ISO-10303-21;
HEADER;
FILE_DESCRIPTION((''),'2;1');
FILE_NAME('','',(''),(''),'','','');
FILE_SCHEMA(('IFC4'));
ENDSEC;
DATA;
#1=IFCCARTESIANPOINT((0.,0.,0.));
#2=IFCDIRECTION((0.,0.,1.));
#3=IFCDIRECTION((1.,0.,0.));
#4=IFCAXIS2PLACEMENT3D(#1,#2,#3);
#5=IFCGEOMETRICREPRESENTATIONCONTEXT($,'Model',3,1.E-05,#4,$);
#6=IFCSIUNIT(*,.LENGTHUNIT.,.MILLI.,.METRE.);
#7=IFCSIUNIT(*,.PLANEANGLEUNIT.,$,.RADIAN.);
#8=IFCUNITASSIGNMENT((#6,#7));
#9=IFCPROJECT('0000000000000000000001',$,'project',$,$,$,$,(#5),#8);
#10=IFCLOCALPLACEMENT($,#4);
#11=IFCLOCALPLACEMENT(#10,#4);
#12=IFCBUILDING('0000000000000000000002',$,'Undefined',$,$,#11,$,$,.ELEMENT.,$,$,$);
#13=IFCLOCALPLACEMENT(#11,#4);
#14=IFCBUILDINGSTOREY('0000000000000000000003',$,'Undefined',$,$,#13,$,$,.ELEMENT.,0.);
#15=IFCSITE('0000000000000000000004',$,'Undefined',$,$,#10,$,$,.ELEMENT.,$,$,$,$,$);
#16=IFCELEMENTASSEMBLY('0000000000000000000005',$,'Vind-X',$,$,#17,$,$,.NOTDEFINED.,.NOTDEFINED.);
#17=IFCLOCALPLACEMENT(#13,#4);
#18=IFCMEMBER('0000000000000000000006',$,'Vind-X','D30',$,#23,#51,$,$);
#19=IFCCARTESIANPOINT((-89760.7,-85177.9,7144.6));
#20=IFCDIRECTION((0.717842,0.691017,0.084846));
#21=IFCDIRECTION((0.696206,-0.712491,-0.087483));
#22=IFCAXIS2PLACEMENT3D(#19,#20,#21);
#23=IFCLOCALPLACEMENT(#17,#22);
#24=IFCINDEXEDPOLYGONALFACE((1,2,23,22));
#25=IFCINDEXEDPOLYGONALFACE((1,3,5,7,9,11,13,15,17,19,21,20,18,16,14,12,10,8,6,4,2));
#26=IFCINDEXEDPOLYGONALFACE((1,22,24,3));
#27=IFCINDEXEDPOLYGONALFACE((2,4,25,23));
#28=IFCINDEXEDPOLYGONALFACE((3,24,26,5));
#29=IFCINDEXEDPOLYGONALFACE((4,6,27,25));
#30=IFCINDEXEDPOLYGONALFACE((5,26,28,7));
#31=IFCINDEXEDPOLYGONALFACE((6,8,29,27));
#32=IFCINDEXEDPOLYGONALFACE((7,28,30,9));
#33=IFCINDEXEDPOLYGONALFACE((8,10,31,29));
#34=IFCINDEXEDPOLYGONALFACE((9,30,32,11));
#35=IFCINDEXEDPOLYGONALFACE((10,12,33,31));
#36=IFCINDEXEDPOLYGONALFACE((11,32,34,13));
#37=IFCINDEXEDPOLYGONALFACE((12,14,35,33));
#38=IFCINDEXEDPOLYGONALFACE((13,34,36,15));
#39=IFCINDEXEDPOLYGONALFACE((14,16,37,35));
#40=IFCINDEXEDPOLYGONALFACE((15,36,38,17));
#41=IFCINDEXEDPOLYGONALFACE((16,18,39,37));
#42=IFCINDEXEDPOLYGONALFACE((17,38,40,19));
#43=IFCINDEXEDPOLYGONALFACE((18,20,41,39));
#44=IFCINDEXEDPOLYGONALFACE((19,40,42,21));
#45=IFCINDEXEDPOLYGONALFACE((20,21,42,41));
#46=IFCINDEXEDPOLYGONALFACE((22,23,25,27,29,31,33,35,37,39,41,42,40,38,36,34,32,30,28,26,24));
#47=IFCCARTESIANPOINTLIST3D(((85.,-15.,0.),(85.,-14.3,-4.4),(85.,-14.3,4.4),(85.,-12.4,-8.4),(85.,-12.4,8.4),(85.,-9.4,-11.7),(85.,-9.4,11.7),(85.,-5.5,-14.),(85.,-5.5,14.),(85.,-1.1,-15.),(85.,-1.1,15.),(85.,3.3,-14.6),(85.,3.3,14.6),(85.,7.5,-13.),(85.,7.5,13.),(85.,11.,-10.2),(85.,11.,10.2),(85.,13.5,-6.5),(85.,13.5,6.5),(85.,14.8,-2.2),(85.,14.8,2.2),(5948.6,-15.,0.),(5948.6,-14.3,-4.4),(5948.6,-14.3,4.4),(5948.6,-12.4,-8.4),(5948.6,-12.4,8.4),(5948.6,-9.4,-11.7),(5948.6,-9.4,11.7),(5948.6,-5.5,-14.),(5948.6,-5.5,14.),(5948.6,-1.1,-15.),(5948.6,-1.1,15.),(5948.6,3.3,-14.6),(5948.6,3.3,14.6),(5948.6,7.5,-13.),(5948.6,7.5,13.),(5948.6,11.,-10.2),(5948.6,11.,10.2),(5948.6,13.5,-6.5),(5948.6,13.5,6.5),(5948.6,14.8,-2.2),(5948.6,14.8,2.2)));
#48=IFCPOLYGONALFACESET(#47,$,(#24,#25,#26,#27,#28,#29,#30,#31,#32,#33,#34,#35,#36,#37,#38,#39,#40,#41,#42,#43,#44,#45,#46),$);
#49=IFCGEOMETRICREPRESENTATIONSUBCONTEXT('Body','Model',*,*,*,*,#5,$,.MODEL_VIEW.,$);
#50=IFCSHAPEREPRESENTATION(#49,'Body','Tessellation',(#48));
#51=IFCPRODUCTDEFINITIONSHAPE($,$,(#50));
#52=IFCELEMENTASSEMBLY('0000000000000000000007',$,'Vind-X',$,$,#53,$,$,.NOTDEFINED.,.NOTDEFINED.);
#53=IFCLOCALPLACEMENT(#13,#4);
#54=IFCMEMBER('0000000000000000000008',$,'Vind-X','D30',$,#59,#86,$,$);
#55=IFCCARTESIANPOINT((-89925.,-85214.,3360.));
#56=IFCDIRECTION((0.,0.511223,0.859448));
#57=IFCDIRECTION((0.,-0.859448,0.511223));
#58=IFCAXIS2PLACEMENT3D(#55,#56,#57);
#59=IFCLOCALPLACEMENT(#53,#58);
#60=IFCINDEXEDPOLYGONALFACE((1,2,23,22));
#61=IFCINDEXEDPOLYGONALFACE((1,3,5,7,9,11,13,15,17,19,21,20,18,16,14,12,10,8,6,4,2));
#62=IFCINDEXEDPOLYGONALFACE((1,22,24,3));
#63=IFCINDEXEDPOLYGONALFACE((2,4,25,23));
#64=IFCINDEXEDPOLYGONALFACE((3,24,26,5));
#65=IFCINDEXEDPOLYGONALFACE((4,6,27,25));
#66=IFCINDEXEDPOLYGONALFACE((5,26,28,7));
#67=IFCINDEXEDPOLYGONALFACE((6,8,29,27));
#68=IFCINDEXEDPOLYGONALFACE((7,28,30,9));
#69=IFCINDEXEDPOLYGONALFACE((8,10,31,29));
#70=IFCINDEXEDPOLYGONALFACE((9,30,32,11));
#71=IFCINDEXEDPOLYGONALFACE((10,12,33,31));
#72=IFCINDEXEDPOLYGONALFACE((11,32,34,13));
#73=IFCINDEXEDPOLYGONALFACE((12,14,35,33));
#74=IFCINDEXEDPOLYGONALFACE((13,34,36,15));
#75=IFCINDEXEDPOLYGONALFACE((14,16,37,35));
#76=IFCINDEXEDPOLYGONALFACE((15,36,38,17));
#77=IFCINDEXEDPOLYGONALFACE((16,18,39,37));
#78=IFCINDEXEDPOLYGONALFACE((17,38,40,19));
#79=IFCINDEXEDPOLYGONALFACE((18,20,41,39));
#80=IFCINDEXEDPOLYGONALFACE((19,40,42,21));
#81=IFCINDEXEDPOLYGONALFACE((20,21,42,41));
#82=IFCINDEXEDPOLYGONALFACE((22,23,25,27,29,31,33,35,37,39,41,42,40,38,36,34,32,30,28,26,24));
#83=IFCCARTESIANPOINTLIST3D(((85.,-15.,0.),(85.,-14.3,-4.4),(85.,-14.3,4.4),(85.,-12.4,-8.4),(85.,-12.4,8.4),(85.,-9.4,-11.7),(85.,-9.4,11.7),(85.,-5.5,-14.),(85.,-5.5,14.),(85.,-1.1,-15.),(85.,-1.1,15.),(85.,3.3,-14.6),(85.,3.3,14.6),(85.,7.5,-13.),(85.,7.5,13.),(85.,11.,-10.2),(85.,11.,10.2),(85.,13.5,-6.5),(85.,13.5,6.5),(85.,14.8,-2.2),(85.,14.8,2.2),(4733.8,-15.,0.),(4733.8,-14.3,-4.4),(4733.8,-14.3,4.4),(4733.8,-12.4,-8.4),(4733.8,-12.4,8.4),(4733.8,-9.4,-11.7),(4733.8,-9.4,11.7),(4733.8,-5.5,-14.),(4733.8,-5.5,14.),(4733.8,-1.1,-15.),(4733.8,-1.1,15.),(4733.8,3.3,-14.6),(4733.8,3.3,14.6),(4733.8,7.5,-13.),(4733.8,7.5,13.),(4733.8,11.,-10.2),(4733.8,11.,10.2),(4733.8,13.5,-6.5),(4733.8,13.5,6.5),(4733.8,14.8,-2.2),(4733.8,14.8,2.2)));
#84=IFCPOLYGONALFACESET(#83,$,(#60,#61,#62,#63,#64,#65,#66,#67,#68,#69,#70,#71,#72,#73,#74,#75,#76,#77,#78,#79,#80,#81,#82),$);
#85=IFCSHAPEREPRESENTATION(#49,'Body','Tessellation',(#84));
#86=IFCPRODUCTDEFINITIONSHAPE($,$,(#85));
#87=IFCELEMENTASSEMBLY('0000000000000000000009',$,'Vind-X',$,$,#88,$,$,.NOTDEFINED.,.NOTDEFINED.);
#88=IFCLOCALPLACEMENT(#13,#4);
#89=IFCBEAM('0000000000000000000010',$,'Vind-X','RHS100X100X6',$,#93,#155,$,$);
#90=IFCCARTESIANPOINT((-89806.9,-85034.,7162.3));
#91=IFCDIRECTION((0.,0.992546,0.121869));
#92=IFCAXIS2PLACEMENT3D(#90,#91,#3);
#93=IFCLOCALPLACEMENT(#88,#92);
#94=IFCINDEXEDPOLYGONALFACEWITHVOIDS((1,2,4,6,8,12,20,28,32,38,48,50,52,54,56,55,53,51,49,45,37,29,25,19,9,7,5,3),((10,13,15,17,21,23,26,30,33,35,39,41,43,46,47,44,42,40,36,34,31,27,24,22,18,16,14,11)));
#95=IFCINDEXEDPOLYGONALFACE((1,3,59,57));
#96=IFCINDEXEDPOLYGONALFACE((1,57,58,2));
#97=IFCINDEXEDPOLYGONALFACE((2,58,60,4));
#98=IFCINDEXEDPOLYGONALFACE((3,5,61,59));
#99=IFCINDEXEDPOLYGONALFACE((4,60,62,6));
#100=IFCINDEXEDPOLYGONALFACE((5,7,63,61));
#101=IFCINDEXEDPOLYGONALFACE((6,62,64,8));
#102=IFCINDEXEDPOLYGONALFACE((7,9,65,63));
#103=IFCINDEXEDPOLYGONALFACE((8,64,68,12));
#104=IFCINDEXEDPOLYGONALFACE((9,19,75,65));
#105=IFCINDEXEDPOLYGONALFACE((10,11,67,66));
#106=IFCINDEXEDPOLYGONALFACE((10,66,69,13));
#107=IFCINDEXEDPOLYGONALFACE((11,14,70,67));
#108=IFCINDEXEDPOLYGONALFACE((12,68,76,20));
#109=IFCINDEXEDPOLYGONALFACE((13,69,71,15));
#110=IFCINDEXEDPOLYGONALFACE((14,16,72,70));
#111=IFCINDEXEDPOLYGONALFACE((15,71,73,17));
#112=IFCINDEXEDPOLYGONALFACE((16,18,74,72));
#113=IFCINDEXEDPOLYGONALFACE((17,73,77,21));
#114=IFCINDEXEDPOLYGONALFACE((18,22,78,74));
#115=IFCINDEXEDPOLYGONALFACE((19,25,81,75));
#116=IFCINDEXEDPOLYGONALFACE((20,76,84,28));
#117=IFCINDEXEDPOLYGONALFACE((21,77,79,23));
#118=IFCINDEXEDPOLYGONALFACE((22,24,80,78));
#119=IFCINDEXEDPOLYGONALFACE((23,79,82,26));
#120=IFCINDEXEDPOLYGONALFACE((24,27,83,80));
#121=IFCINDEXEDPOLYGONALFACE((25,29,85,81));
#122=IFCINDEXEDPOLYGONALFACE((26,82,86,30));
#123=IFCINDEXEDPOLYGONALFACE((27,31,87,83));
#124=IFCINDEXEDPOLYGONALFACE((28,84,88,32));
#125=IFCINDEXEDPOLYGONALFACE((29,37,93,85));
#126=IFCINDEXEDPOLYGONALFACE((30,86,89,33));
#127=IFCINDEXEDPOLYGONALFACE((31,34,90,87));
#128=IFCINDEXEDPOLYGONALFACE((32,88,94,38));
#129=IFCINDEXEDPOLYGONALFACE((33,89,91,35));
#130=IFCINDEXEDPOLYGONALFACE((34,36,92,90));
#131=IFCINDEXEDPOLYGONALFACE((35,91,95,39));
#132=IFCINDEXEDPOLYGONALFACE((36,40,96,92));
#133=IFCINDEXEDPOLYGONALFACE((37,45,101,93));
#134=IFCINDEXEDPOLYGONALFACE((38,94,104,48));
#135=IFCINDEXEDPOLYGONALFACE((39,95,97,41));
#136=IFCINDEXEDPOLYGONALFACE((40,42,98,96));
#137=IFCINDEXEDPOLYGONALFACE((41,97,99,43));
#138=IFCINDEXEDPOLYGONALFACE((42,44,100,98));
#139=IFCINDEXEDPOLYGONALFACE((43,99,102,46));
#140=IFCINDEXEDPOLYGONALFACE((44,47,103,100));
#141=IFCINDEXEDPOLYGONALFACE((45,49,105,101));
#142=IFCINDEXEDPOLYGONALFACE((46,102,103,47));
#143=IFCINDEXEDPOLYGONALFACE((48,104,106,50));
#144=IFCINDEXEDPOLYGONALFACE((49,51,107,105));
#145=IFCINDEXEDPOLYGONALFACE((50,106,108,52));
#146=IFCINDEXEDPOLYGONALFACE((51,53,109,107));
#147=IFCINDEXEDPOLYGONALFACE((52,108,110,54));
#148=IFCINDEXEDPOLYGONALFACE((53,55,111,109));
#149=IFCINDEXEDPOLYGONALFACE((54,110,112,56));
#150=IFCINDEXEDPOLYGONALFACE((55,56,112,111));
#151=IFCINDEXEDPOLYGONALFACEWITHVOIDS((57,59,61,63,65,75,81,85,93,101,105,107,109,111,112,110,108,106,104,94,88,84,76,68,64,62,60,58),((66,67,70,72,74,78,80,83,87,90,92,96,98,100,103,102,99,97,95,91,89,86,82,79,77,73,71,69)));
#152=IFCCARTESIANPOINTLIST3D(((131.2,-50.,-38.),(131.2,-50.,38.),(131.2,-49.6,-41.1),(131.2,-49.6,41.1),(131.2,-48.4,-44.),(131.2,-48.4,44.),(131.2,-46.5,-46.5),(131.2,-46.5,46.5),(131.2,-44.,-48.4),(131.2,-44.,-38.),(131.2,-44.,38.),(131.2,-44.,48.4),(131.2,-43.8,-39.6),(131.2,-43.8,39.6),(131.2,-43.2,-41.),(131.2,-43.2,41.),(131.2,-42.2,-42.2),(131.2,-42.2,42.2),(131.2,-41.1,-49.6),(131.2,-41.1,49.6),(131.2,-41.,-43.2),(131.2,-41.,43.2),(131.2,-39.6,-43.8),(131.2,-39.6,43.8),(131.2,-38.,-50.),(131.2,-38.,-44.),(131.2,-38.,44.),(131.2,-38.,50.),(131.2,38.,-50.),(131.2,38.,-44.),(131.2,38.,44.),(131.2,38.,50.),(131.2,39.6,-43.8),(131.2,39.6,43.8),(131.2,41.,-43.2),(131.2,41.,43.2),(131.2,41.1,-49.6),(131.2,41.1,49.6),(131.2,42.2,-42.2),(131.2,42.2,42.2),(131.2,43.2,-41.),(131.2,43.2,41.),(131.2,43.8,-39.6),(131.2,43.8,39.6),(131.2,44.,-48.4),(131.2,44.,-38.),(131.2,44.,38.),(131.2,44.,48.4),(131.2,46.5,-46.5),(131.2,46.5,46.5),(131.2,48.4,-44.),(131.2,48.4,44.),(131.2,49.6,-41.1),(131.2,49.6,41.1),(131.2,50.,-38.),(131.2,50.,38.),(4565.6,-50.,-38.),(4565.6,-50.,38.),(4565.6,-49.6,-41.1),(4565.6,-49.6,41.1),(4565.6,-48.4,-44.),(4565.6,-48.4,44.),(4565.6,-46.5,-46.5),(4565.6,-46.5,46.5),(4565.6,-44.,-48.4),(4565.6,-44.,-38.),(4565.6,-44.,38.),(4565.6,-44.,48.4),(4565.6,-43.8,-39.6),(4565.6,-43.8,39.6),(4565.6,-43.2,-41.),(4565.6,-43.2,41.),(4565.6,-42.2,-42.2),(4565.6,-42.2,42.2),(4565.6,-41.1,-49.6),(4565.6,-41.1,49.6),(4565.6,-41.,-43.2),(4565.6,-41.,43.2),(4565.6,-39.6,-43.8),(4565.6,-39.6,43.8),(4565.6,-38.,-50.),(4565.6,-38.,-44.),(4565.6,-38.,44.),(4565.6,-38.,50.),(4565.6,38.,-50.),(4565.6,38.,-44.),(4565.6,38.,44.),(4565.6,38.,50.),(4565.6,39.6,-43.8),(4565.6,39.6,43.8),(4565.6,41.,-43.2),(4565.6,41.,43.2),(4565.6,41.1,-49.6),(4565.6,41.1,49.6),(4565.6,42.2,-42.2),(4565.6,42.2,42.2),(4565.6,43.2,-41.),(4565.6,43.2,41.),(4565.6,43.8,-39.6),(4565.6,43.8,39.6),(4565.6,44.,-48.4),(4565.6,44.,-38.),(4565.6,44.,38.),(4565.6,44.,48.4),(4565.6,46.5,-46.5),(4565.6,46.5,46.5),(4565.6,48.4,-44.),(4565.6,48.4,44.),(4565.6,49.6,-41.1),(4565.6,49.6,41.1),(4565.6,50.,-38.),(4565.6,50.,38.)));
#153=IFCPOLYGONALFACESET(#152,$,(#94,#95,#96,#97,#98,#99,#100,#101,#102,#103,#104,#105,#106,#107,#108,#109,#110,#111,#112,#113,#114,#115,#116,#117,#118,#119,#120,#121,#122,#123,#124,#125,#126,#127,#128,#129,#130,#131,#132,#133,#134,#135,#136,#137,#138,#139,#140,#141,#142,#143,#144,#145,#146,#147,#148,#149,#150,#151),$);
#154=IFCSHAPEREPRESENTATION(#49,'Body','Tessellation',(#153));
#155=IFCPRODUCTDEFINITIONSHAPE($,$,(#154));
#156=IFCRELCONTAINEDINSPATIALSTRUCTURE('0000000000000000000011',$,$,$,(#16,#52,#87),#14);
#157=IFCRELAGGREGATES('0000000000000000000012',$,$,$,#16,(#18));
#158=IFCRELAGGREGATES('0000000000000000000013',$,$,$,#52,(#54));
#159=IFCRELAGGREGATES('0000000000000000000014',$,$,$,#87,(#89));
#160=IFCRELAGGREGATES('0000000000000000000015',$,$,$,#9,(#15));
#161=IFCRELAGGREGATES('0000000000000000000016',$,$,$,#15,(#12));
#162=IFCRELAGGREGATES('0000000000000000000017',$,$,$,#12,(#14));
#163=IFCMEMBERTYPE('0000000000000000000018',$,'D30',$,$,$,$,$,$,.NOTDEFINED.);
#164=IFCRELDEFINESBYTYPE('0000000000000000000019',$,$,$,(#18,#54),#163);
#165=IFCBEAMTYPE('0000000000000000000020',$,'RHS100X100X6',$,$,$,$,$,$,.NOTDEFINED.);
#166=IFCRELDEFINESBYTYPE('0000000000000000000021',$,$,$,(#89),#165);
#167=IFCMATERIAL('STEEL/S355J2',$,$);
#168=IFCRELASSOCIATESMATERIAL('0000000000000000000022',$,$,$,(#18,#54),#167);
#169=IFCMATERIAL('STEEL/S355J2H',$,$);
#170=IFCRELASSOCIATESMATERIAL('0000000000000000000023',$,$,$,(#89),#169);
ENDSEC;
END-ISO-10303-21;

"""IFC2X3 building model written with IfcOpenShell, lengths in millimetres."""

from ifc_helpers import new_model, si_unit, frame, origin_with_axes, origin_2d_with_axis, place, context, subcontext, project, spatial, hollow_rectangle, circle, extrude, clip, halfspace, material, type_object, element, aggregate, save


model = new_model("IFC2X3")

# Units and contexts
model_context = context("Model", 3, precision=1e-05, world=origin_with_axes())
body_context = subcontext(model_context, "Body", "Model", "MODEL_VIEW")
ifc_project = project(units=[si_unit("LENGTHUNIT", "METRE", prefix="MILLI"), si_unit("PLANEANGLEUNIT", "RADIAN")], contexts=[model_context])

# Site, building, storey
site_placement = place(None, origin_with_axes())
site = spatial("IfcSite", under=ifc_project, at=site_placement, Name="Undefined", CompositionType="ELEMENT")
building_placement = place(site_placement, origin_with_axes())
building = spatial("IfcBuilding", under=site, at=building_placement, Name="Undefined", CompositionType="ELEMENT")
storey_placement = place(building_placement, origin_with_axes())
storey = spatial("IfcBuildingStorey", under=building, at=storey_placement, Name="Undefined", CompositionType="ELEMENT", Elevation=0.0)

# Shared definitions
ifc_material_1 = material(Name="STEEL/S355J2")

# Element assembly, member
assembly_1_placement = place(storey_placement, origin_with_axes())
assembly_1 = element("IfcElementAssembly", 1, at=assembly_1_placement, inside=storey, Name="Vind-X", AssemblyPlace="NOTDEFINED", PredefinedType="NOTDEFINED")
member_type_1 = type_object("IfcMemberType", Name="D30", PredefinedType="NOTDEFINED")
member_1_placement = place(assembly_1_placement, frame((-89760.7, -85177.9, 7144.6), z_axis=(0.717842, 0.691017, 0.084846), x_axis=(0.696206, -0.712491, -0.087483)))
member_1 = element("IfcMember", 2, at=member_1_placement, type_object=member_type_1, material=ifc_material_1, Name="Vind-X", Description="D30", context=body_context, shape_type="Clipping", body=[
    clip(clip(extrude(circle(Radius=15.0, at=origin_2d_with_axis()), frame((6613.6, 0.0, 0.0), z_axis=(-1.0, 0.0, 0.0), x_axis=(0.0, -1.0, 0.0)), (0.0, 0.0, 1.0), 6613.6), halfspace(frame((5948.6, -6.0, 10.2), z_axis=(1.0, 0.0, 0.0), x_axis=(0.0, 1.0, 0.0)), False)), halfspace(frame((85.0, -6.0, 16.0), z_axis=(1.0, 0.0, 0.0), x_axis=(0.0, 1.0, 0.0)), True)),
])

# Element assembly, member
assembly_2_placement = place(storey_placement, origin_with_axes())
assembly_2 = element("IfcElementAssembly", 3, at=assembly_2_placement, inside=storey, Name="Vind-X", AssemblyPlace="NOTDEFINED", PredefinedType="NOTDEFINED")
member_2_placement = place(assembly_2_placement, frame((-89925.0, -85214.0, 3360.0), z_axis=(0.0, 0.511223, 0.859448), x_axis=(0.0, -0.859448, 0.511223)))
member_2 = element("IfcMember", 4, at=member_2_placement, type_object=member_type_1, material=ifc_material_1, Name="Vind-X", Description="D30", context=body_context, shape_type="Clipping", body=[
    clip(clip(extrude(circle(Radius=15.0, at=origin_2d_with_axis()), frame((5398.8, 0.0, 0.0), z_axis=(-1.0, 0.0, 0.0), x_axis=(0.0, -1.0, 0.0)), (0.0, 0.0, 1.0), 5398.8), halfspace(frame((4733.8, -6.0, 10.2), z_axis=(1.0, 0.0, 0.0), x_axis=(0.0, 1.0, 0.0)), False)), halfspace(frame((85.0, -6.0, 16.0), z_axis=(1.0, 0.0, 0.0), x_axis=(0.0, 1.0, 0.0)), True)),
])

# Element assembly, beam
assembly_3_placement = place(storey_placement, origin_with_axes())
assembly_3 = element("IfcElementAssembly", 5, at=assembly_3_placement, inside=storey, Name="Vind-X", AssemblyPlace="NOTDEFINED", PredefinedType="NOTDEFINED")
ifc_material_2 = material(Name="STEEL/S355J2H")
beam_type_1 = type_object("IfcBeamType", Name="RHS100X100X6", PredefinedType="NOTDEFINED")
beam_1_placement = place(assembly_3_placement, frame((-89806.9, -85034.0, 7162.3), z_axis=(0.0, 0.992546, 0.121869), x_axis=(1.0, 0.0, 0.0)))
beam_1 = element("IfcBeam", 6, at=beam_1_placement, type_object=beam_type_1, material=ifc_material_2, Name="Vind-X", Description="RHS100X100X6", context=body_context, shape_type="Clipping", body=[
    clip(clip(extrude(hollow_rectangle(XDim=100.0, YDim=100.0, WallThickness=6.0, InnerFilletRadius=6.0, OuterFilletRadius=12.0, at=origin_2d_with_axis()), frame((4644.6, 0.0, 0.0), z_axis=(-1.0, 0.0, 0.0), x_axis=(0.0, -1.0, 0.0)), (0.0, 0.0, 1.0), 4644.6), halfspace(frame((4565.6, 22.5, 0.0), z_axis=(-1.0, 0.0, 0.0), x_axis=(0.0, 0.0, 1.0)), True)), halfspace(frame((131.2, 22.5, 0.0), z_axis=(1.0, 0.0, 0.0), x_axis=(0.0, 0.0, -1.0)), True)),
])

aggregate(assembly_1, [member_1])
aggregate(assembly_2, [member_2])
aggregate(assembly_3, [beam_1])

save(model, "model.ifc")
